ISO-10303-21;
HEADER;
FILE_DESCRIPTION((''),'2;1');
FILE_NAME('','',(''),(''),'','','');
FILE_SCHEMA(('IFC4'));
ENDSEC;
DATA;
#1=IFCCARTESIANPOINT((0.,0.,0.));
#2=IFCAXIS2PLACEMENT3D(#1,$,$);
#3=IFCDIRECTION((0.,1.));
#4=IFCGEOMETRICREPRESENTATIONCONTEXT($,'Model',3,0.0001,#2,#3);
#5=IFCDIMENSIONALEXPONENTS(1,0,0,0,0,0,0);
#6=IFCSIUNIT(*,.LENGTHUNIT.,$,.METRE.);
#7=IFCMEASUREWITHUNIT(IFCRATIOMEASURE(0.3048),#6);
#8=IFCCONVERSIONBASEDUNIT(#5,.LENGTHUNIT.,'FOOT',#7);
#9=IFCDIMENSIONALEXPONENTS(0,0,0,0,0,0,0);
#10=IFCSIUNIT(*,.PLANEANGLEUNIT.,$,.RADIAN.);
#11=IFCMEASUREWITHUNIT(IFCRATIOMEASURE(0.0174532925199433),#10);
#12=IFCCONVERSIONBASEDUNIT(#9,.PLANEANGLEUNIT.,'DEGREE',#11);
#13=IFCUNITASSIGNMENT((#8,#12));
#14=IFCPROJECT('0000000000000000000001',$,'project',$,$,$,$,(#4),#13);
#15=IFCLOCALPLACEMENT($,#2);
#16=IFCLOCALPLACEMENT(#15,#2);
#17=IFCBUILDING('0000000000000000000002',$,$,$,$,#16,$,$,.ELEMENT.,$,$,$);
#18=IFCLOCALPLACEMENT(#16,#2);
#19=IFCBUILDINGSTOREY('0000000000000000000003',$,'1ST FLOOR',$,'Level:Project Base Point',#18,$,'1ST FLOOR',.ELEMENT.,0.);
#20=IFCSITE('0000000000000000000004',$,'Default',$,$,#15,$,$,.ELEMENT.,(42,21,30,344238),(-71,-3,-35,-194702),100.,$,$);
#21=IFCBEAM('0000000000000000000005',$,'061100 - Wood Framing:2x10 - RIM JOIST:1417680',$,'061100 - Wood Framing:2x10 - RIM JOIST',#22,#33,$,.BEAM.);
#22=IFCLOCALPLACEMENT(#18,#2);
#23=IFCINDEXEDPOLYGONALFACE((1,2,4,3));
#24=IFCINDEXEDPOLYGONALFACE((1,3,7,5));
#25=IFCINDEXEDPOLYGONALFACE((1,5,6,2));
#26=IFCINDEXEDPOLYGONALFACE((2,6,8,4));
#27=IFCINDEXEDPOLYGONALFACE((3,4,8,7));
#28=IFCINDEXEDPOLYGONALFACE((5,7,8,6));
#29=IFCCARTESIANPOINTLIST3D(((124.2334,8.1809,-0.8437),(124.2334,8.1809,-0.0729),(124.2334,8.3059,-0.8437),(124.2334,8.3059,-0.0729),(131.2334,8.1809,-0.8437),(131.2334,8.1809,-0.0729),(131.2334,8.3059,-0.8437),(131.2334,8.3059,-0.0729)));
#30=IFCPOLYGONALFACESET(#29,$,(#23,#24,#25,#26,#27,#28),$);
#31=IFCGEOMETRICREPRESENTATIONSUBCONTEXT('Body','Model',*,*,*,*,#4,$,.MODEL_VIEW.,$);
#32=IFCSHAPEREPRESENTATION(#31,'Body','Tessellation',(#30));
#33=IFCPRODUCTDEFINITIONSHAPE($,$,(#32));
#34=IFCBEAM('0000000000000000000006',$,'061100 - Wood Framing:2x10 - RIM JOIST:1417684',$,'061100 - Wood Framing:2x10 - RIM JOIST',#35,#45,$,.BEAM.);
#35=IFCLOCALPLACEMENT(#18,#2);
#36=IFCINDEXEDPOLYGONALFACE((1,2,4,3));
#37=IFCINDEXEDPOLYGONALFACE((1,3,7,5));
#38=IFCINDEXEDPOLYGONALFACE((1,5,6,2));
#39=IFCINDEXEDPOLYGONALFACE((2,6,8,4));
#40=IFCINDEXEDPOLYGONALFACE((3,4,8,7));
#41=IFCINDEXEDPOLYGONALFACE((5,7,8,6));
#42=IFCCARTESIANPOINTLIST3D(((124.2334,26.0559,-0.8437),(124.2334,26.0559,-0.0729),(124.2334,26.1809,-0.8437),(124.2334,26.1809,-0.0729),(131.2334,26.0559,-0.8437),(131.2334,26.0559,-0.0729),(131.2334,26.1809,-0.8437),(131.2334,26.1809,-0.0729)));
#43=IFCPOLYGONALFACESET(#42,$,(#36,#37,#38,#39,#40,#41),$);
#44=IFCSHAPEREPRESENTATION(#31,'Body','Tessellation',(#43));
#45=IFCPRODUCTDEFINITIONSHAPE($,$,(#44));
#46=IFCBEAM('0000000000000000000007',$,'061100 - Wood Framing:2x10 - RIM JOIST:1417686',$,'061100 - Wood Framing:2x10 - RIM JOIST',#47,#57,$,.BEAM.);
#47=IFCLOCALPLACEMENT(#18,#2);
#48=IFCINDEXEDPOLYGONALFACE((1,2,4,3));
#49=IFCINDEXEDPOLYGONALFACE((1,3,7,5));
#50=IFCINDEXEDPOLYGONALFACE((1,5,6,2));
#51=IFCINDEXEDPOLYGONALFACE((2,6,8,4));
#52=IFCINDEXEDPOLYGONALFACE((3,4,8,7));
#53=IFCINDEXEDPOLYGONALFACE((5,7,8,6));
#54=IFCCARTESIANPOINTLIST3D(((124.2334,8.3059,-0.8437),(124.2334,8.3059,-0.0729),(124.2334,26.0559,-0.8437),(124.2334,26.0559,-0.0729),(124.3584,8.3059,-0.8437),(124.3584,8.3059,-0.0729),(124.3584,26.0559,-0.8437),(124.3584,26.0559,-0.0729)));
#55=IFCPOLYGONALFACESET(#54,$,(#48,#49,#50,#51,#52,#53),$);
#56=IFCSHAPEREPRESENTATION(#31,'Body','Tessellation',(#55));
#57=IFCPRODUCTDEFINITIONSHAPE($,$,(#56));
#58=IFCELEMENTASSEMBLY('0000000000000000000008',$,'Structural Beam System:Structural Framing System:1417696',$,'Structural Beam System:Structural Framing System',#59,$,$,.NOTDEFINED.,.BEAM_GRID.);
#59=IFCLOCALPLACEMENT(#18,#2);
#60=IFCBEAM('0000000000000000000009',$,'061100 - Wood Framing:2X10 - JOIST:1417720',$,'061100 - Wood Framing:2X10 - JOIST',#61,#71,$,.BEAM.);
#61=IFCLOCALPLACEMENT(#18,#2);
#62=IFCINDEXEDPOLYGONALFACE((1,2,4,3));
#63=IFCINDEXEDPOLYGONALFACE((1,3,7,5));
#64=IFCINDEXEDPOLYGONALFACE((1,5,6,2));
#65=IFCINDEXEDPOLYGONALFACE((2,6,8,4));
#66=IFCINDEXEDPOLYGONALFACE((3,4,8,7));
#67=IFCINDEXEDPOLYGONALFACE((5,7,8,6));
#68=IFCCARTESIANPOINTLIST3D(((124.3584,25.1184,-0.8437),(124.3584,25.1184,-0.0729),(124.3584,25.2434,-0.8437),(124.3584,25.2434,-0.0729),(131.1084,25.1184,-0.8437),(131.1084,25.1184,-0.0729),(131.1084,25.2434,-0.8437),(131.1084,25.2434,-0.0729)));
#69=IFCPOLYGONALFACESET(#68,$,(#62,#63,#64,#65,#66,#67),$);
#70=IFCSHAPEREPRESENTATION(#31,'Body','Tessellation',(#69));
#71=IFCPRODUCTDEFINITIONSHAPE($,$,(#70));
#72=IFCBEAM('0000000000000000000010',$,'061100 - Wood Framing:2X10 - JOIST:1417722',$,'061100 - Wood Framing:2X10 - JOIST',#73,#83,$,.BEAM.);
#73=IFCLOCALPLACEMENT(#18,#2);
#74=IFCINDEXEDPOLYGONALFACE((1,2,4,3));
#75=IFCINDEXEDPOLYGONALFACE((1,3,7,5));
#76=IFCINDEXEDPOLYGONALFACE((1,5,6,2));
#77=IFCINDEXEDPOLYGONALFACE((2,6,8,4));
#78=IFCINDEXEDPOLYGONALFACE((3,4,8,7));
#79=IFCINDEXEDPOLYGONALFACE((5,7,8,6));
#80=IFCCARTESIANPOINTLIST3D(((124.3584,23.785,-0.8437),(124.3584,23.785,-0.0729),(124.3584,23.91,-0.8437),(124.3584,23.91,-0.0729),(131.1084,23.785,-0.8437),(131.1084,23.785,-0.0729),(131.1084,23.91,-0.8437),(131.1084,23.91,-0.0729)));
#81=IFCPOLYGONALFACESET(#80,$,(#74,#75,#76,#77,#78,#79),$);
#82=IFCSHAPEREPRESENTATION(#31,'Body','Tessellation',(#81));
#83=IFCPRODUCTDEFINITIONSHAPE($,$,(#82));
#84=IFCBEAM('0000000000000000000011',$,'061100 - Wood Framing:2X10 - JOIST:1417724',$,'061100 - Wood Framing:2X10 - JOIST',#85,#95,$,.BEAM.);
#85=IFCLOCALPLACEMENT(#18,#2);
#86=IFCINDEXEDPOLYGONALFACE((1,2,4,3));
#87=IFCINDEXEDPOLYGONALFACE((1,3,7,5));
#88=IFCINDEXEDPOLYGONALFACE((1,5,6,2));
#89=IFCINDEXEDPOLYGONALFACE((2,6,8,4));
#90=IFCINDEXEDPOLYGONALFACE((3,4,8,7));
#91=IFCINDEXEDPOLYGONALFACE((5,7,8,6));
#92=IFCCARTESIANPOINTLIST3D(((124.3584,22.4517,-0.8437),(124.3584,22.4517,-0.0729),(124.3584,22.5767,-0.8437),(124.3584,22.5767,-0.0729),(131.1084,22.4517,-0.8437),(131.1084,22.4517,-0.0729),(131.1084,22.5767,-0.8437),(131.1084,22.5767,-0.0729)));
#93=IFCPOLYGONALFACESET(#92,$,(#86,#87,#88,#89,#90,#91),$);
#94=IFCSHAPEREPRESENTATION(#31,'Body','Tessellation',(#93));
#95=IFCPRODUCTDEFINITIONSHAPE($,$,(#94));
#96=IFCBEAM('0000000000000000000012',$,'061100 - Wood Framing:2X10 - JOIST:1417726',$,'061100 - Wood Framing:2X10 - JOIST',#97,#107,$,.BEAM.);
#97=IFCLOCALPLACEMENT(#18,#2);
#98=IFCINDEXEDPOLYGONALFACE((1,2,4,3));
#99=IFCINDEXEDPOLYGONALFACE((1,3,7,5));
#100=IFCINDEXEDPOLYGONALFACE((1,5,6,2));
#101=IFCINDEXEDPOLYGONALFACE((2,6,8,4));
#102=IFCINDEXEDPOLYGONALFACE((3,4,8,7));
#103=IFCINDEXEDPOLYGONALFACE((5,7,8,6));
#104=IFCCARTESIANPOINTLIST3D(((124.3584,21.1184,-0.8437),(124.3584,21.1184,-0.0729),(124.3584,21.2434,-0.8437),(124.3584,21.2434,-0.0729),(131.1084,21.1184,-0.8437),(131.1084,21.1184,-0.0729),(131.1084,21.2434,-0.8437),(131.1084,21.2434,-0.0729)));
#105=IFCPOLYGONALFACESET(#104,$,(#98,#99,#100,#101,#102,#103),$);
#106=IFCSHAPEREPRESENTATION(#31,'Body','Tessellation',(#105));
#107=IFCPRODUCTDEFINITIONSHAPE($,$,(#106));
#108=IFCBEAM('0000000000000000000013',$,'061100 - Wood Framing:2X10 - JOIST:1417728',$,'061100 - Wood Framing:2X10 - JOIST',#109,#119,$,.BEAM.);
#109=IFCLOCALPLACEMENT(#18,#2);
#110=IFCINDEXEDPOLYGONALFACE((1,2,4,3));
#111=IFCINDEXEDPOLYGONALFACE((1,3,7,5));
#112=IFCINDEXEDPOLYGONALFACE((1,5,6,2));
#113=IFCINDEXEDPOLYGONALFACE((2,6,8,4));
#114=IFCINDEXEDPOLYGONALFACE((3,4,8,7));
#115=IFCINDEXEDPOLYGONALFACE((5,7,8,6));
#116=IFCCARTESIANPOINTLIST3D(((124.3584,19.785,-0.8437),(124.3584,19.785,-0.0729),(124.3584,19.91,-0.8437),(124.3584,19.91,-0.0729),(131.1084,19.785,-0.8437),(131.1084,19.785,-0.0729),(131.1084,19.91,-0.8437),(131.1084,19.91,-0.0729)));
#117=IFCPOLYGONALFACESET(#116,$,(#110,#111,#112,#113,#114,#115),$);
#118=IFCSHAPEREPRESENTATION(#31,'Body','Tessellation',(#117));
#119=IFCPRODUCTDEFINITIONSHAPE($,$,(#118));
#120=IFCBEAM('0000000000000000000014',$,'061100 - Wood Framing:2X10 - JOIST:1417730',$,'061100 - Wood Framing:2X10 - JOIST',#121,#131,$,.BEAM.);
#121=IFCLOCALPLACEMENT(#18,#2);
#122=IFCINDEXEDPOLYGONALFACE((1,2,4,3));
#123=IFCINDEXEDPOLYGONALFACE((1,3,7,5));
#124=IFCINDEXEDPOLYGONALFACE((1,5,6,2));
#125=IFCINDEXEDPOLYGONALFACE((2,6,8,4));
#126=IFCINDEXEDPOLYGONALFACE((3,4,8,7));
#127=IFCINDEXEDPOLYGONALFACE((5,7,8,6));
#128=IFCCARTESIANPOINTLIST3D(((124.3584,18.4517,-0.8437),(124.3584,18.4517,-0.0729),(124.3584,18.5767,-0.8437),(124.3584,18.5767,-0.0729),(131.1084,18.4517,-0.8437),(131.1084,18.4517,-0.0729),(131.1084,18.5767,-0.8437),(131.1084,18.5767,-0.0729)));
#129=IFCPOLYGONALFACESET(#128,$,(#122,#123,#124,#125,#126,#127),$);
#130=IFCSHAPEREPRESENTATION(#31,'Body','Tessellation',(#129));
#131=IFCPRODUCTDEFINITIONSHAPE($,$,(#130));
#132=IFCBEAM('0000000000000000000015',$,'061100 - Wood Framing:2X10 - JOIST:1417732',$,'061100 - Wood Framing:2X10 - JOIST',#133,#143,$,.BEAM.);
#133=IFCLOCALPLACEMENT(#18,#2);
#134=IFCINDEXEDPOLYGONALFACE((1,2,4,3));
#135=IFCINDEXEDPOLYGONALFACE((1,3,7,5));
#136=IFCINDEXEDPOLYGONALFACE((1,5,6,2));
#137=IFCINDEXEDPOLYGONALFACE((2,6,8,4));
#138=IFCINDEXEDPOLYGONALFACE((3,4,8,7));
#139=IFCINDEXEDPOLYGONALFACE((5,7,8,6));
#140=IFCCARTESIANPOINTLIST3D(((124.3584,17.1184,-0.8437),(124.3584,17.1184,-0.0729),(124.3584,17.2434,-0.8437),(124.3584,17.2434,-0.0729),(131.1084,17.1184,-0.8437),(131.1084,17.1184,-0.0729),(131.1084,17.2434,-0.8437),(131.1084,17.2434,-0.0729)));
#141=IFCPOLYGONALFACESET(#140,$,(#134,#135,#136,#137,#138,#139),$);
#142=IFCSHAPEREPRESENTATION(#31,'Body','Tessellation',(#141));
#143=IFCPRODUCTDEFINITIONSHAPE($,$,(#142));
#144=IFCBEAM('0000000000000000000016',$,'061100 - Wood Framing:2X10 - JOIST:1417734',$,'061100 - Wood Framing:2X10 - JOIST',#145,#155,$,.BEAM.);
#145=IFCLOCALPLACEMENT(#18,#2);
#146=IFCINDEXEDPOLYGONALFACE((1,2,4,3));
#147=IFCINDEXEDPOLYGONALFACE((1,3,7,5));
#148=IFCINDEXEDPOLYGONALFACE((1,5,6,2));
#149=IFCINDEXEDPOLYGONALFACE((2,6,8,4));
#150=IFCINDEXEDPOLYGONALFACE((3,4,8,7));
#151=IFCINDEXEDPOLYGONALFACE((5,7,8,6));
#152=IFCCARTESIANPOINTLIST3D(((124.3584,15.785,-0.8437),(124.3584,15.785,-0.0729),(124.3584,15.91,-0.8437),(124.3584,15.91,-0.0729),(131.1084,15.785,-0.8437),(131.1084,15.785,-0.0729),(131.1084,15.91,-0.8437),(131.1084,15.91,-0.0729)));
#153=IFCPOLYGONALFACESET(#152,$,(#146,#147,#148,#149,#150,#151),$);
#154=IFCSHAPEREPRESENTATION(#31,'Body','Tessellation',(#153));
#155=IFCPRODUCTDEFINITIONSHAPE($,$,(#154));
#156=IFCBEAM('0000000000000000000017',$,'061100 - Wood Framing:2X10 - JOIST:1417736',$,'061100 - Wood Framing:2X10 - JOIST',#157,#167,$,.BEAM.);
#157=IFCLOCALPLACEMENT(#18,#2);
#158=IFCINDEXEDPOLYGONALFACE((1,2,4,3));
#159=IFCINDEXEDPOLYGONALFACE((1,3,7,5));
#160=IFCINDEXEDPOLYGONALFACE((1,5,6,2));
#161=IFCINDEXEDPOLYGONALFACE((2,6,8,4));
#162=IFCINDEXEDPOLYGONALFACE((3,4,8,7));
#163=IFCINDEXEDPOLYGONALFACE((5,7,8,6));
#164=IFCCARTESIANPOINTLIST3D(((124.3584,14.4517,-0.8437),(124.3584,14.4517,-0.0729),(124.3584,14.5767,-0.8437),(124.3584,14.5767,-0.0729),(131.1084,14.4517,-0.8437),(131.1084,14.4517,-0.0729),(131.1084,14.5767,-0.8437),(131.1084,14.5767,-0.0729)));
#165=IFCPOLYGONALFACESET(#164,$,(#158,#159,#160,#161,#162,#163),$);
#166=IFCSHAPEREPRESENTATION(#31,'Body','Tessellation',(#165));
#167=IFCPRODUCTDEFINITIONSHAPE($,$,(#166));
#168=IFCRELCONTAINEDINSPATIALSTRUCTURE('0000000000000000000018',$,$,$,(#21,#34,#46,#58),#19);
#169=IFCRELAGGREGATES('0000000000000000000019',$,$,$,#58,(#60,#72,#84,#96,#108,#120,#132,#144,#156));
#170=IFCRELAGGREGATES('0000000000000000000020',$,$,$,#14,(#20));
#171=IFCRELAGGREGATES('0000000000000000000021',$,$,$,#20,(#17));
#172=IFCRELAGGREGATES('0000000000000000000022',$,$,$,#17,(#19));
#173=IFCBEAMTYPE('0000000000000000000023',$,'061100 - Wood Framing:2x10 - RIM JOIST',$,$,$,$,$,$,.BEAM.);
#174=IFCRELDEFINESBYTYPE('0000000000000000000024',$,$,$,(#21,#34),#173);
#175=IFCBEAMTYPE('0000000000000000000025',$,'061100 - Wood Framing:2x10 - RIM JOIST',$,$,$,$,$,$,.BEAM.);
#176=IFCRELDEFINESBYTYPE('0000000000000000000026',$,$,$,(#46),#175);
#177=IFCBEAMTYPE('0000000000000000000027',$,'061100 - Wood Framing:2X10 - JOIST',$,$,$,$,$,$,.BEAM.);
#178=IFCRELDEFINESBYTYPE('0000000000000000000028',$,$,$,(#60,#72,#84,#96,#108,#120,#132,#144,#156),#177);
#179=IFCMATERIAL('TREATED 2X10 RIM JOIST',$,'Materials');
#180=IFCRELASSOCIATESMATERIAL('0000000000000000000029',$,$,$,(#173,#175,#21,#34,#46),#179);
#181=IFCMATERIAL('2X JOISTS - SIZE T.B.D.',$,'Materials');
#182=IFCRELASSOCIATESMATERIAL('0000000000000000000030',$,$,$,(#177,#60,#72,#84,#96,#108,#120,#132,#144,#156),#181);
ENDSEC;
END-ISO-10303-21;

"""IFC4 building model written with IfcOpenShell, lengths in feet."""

from ifc_helpers import new_model, entity, si_unit, converted_unit, direction, frame, frame_2d, origin, origin_2d_with_axis, place, context, subcontext, project, spatial, rectangle, extrude, source, transform, mapped, material, material_profile, profile_set, profile_usage, type_object, type_shapes, element, aggregate, save


model = new_model("IFC4")

# Units and contexts
model_context = context("Model", 3, precision=0.0001, world=origin(), true_north=direction((0.0, 1.0)))
body_context = subcontext(model_context, "Body", "Model", "MODEL_VIEW")
ifc_project = project(units=[converted_unit("LENGTHUNIT", "FOOT", entity("IfcRatioMeasure", 0.3048), si_unit("LENGTHUNIT", "METRE"), dimensions=[1, 0, 0, 0, 0, 0, 0]), converted_unit("PLANEANGLEUNIT", "DEGREE", entity("IfcRatioMeasure", 0.0174532925199433), si_unit("PLANEANGLEUNIT", "RADIAN"), dimensions=[0, 0, 0, 0, 0, 0, 0])], contexts=[model_context])

# Site, building, storey
site_placement = place(None, origin())
site = spatial("IfcSite", under=ifc_project, at=site_placement, Name="Default", CompositionType="ELEMENT", RefLatitude=(42, 21, 30, 344238), RefLongitude=(-71, -3, -35, -194702), RefElevation=100.0)
building_placement = place(site_placement, origin())
building = spatial("IfcBuilding", under=site, at=building_placement, CompositionType="ELEMENT")
storey_placement = place(building_placement, origin())
storey = spatial("IfcBuildingStorey", under=building, at=storey_placement, Name="1ST FLOOR", ObjectType="Level:Project Base Point", LongName="1ST FLOOR", CompositionType="ELEMENT", Elevation=0.0)

# Beams
ifc_material_1 = material(Name="TREATED 2X10 RIM JOIST", Category="Materials")
ifc_material_profile_1 = material_profile(ifc_material_1, rectangle(XDim=0.7708, YDim=0.125, at=origin_2d_with_axis()), Name="2x10 - RIM JOIST")
ifc_profile_set_1 = profile_set([ifc_material_profile_1], Name="2x10 - RIM JOIST")
ifc_profile_usage_1 = profile_usage(ifc_profile_set_1, cardinal=8)
beam_type_1 = type_object("IfcBeamType", Name="061100 - Wood Framing:2x10 - RIM JOIST", PredefinedType="BEAM", material=ifc_profile_set_1)
shared_shape_1 = source(origin(), body_context, "Body", "SweptSolid", [
    extrude(rectangle(XDim=0.7708, YDim=0.125, at=origin_2d_with_axis()), frame((-3.5, 0.0, 0.0), z_axis=(1.0, 0.0, 0.0), x_axis=(0.0, 0.0, -1.0)), (0.0, 0.0, 1.0), 7.0),
])
type_shapes(beam_type_1, [shared_shape_1])
beam_1_placement = place(storey_placement, frame((127.7334, 8.2434, -0.4583)))
element("IfcBeam", 1, at=beam_1_placement, inside=storey, type_object=beam_type_1, material=ifc_profile_usage_1, Name="061100 - Wood Framing:2x10 - RIM JOIST:1417680", ObjectType="061100 - Wood Framing:2x10 - RIM JOIST", PredefinedType="BEAM", context=body_context, shape_type="MappedRepresentation", body=[
    mapped(shared_shape_1, transform((0.0, 0.0, 0.0), scale=1.0)),
])
ifc_profile_usage_2 = profile_usage(ifc_profile_set_1, cardinal=8)
beam_2_placement = place(storey_placement, frame((127.7334, 26.1184, -0.4583), z_axis=(0.0, 0.0, 1.0), x_axis=(-1.0, 0.0, 0.0)))
element("IfcBeam", 2, at=beam_2_placement, inside=storey, type_object=beam_type_1, material=ifc_profile_usage_2, Name="061100 - Wood Framing:2x10 - RIM JOIST:1417684", ObjectType="061100 - Wood Framing:2x10 - RIM JOIST", PredefinedType="BEAM", context=body_context, shape_type="MappedRepresentation", body=[
    mapped(shared_shape_1, transform((0.0, 0.0, 0.0), scale=1.0)),
])
ifc_profile_usage_3 = profile_usage(ifc_profile_set_1, cardinal=8)
beam_type_2 = type_object("IfcBeamType", Name="061100 - Wood Framing:2x10 - RIM JOIST", PredefinedType="BEAM", material=ifc_profile_set_1)
shared_shape_2 = source(origin(), body_context, "Body", "SweptSolid", [
    extrude(rectangle(XDim=0.7708, YDim=0.125, at=frame_2d((0.0, 0.0), x_axis=(1.0, 0.0))), frame((-8.875, 0.0, 0.0), z_axis=(1.0, 0.0, 0.0), x_axis=(0.0, 0.0, -1.0)), (0.0, 0.0, 1.0), 17.75),
])
type_shapes(beam_type_2, [shared_shape_2])
beam_3_placement = place(storey_placement, frame((124.2959, 17.1809, -0.4583), z_axis=(0.0, 0.0, 1.0), x_axis=(0.0, -1.0, 0.0)))
element("IfcBeam", 3, at=beam_3_placement, inside=storey, type_object=beam_type_2, material=ifc_profile_usage_3, Name="061100 - Wood Framing:2x10 - RIM JOIST:1417686", ObjectType="061100 - Wood Framing:2x10 - RIM JOIST", PredefinedType="BEAM", context=body_context, shape_type="MappedRepresentation", body=[
    mapped(shared_shape_2, transform((0.0, 0.0, 0.0), scale=1.0)),
])

# Element assembly, beams
assembly_placement = place(storey_placement, origin())
assembly = element("IfcElementAssembly", 4, at=assembly_placement, inside=storey, Name="Structural Beam System:Structural Framing System:1417696", ObjectType="Structural Beam System:Structural Framing System", AssemblyPlace="NOTDEFINED", PredefinedType="BEAM_GRID")
ifc_material_2 = material(Name="2X JOISTS - SIZE T.B.D.", Category="Materials")
ifc_material_profile_2 = material_profile(ifc_material_2, rectangle(XDim=0.7708, YDim=0.125, at=frame_2d((0.0, 0.0), x_axis=(1.0, 0.0))), Name="2X10 - JOIST")
ifc_profile_set_2 = profile_set([ifc_material_profile_2], Name="2X10 - JOIST")
ifc_profile_usage_4 = profile_usage(ifc_profile_set_2, cardinal=8)
beam_type_3 = type_object("IfcBeamType", Name="061100 - Wood Framing:2X10 - JOIST", PredefinedType="BEAM", material=ifc_profile_set_2)
shared_shape_3 = source(origin(), body_context, "Body", "SweptSolid", [
    extrude(rectangle(XDim=0.7708, YDim=0.125, at=frame_2d((0.0, 0.0), x_axis=(1.0, 0.0))), frame((-3.375, 0.0, 0.0), z_axis=(1.0, 0.0, 0.0), x_axis=(0.0, 0.0, -1.0)), (0.0, 0.0, 1.0), 6.75),
])
type_shapes(beam_type_3, [shared_shape_3])
beam_4_placement = place(assembly_placement, frame((127.7334, 25.1809, -0.4583)))
beam_4 = element("IfcBeam", 5, at=beam_4_placement, type_object=beam_type_3, material=ifc_profile_usage_4, Name="061100 - Wood Framing:2X10 - JOIST:1417720", ObjectType="061100 - Wood Framing:2X10 - JOIST", PredefinedType="BEAM", context=body_context, shape_type="MappedRepresentation", body=[
    mapped(shared_shape_3, transform((0.0, 0.0, 0.0), scale=1.0)),
])
ifc_profile_usage_5 = profile_usage(ifc_profile_set_2, cardinal=8)
beam_5_placement = place(assembly_placement, frame((127.7334, 23.8475, -0.4583)))
beam_5 = element("IfcBeam", 6, at=beam_5_placement, type_object=beam_type_3, material=ifc_profile_usage_5, Name="061100 - Wood Framing:2X10 - JOIST:1417722", ObjectType="061100 - Wood Framing:2X10 - JOIST", PredefinedType="BEAM", context=body_context, shape_type="MappedRepresentation", body=[
    mapped(shared_shape_3, transform((0.0, 0.0, 0.0), scale=1.0)),
])
ifc_profile_usage_6 = profile_usage(ifc_profile_set_2, cardinal=8)
beam_6_placement = place(assembly_placement, frame((127.7334, 22.5142, -0.4583)))
beam_6 = element("IfcBeam", 7, at=beam_6_placement, type_object=beam_type_3, material=ifc_profile_usage_6, Name="061100 - Wood Framing:2X10 - JOIST:1417724", ObjectType="061100 - Wood Framing:2X10 - JOIST", PredefinedType="BEAM", context=body_context, shape_type="MappedRepresentation", body=[
    mapped(shared_shape_3, transform((0.0, 0.0, 0.0), scale=1.0)),
])
ifc_profile_usage_7 = profile_usage(ifc_profile_set_2, cardinal=8)
beam_7_placement = place(assembly_placement, frame((127.7334, 21.1809, -0.4583)))
beam_7 = element("IfcBeam", 8, at=beam_7_placement, type_object=beam_type_3, material=ifc_profile_usage_7, Name="061100 - Wood Framing:2X10 - JOIST:1417726", ObjectType="061100 - Wood Framing:2X10 - JOIST", PredefinedType="BEAM", context=body_context, shape_type="MappedRepresentation", body=[
    mapped(shared_shape_3, transform((0.0, 0.0, 0.0), scale=1.0)),
])
ifc_profile_usage_8 = profile_usage(ifc_profile_set_2, cardinal=8)
beam_8_placement = place(assembly_placement, frame((127.7334, 19.8475, -0.4583)))
beam_8 = element("IfcBeam", 9, at=beam_8_placement, type_object=beam_type_3, material=ifc_profile_usage_8, Name="061100 - Wood Framing:2X10 - JOIST:1417728", ObjectType="061100 - Wood Framing:2X10 - JOIST", PredefinedType="BEAM", context=body_context, shape_type="MappedRepresentation", body=[
    mapped(shared_shape_3, transform((0.0, 0.0, 0.0), scale=1.0)),
])
ifc_profile_usage_9 = profile_usage(ifc_profile_set_2, cardinal=8)
beam_9_placement = place(assembly_placement, frame((127.7334, 18.5142, -0.4583)))
beam_9 = element("IfcBeam", 10, at=beam_9_placement, type_object=beam_type_3, material=ifc_profile_usage_9, Name="061100 - Wood Framing:2X10 - JOIST:1417730", ObjectType="061100 - Wood Framing:2X10 - JOIST", PredefinedType="BEAM", context=body_context, shape_type="MappedRepresentation", body=[
    mapped(shared_shape_3, transform((0.0, 0.0, 0.0), scale=1.0)),
])
ifc_profile_usage_10 = profile_usage(ifc_profile_set_2, cardinal=8)
beam_10_placement = place(assembly_placement, frame((127.7334, 17.1809, -0.4583)))
beam_10 = element("IfcBeam", 11, at=beam_10_placement, type_object=beam_type_3, material=ifc_profile_usage_10, Name="061100 - Wood Framing:2X10 - JOIST:1417732", ObjectType="061100 - Wood Framing:2X10 - JOIST", PredefinedType="BEAM", context=body_context, shape_type="MappedRepresentation", body=[
    mapped(shared_shape_3, transform((0.0, 0.0, 0.0), scale=1.0)),
])
ifc_profile_usage_11 = profile_usage(ifc_profile_set_2, cardinal=8)
beam_11_placement = place(assembly_placement, frame((127.7334, 15.8475, -0.4583)))
beam_11 = element("IfcBeam", 12, at=beam_11_placement, type_object=beam_type_3, material=ifc_profile_usage_11, Name="061100 - Wood Framing:2X10 - JOIST:1417734", ObjectType="061100 - Wood Framing:2X10 - JOIST", PredefinedType="BEAM", context=body_context, shape_type="MappedRepresentation", body=[
    mapped(shared_shape_3, transform((0.0, 0.0, 0.0), scale=1.0)),
])
ifc_profile_usage_12 = profile_usage(ifc_profile_set_2, cardinal=8)
beam_12_placement = place(assembly_placement, frame((127.7334, 14.5142, -0.4583)))
beam_12 = element("IfcBeam", 13, at=beam_12_placement, type_object=beam_type_3, material=ifc_profile_usage_12, Name="061100 - Wood Framing:2X10 - JOIST:1417736", ObjectType="061100 - Wood Framing:2X10 - JOIST", PredefinedType="BEAM", context=body_context, shape_type="MappedRepresentation", body=[
    mapped(shared_shape_3, transform((0.0, 0.0, 0.0), scale=1.0)),
])
aggregate(assembly, [beam_4, beam_5, beam_6, beam_7, beam_8, beam_9, beam_10, beam_11, beam_12])

save(model, "model.ifc")
